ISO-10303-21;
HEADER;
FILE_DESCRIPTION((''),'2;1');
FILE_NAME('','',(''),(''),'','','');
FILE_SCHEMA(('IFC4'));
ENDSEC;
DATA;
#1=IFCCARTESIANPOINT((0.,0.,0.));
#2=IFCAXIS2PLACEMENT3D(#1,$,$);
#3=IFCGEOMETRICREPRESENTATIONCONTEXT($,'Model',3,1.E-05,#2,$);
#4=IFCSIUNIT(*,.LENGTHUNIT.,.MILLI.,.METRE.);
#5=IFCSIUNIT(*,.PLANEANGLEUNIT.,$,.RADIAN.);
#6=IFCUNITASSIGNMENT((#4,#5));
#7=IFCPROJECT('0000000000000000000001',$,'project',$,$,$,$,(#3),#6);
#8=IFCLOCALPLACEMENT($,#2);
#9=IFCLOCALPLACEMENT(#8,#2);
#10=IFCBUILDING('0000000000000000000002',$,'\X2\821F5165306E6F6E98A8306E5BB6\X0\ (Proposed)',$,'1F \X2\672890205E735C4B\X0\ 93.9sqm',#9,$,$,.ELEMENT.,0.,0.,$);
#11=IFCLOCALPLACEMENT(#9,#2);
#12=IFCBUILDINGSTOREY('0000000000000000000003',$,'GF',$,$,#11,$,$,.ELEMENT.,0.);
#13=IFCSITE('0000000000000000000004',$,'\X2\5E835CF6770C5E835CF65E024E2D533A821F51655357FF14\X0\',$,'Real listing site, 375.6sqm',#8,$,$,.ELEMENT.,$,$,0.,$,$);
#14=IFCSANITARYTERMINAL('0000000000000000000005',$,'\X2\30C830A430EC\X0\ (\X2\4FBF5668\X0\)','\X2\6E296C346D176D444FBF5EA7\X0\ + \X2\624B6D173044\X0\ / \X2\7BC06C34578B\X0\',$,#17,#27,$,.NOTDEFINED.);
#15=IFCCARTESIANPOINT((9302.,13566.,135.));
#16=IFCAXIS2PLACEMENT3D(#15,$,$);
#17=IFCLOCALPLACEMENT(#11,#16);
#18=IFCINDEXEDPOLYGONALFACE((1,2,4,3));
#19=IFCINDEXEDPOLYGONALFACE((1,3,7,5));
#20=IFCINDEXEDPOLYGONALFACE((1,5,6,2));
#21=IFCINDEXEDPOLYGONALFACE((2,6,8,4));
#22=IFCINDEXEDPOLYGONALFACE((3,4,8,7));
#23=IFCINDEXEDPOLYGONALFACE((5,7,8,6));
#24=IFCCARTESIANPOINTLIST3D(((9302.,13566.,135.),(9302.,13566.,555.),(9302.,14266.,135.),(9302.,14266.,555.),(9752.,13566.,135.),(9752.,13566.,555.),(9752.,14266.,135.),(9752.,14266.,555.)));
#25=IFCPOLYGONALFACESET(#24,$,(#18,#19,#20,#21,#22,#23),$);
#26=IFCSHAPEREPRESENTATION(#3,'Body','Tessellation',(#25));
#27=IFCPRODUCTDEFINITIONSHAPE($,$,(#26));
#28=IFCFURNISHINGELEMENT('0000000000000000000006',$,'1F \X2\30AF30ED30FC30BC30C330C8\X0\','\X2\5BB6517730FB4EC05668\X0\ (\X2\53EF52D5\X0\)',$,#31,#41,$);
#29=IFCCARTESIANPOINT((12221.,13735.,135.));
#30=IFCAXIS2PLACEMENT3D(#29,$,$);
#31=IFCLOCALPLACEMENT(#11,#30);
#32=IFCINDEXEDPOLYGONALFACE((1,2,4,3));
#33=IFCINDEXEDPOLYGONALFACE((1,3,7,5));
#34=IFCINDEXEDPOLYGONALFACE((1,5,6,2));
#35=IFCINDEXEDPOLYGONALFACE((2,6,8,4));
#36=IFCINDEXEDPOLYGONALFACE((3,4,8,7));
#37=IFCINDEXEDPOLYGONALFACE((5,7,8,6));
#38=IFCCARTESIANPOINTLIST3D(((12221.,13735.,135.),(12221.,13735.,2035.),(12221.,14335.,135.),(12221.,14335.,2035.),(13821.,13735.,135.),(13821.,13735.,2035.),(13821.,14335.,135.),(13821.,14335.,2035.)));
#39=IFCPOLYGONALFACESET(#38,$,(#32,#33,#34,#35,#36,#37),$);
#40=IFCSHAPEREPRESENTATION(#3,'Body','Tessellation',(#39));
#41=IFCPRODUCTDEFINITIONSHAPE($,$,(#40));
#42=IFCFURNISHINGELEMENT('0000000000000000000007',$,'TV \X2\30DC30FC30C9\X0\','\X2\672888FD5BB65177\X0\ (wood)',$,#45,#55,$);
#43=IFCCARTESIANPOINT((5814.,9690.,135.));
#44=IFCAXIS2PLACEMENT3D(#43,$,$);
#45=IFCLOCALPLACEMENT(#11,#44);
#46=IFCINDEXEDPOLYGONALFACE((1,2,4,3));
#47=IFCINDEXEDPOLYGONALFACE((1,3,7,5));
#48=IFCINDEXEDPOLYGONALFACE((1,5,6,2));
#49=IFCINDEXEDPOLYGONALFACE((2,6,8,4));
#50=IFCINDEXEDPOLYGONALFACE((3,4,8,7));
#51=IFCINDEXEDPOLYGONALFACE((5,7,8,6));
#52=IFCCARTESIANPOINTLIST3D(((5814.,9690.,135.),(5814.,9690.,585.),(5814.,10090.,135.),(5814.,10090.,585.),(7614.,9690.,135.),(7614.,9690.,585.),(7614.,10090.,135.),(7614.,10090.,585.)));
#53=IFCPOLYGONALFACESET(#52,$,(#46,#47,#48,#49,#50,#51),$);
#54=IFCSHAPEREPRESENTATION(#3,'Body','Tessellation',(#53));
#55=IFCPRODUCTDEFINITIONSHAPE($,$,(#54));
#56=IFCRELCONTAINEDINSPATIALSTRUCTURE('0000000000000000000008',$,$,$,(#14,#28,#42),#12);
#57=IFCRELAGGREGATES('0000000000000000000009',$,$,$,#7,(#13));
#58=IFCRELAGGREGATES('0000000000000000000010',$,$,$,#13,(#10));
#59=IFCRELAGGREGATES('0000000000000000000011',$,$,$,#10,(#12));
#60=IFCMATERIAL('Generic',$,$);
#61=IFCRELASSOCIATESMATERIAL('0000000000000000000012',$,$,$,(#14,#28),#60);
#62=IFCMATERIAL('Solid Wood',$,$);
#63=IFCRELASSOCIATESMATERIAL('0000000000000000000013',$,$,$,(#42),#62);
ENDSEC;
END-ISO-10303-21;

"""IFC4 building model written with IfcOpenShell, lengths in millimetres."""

from ifc_helpers import new_model, si_unit, frame, frame_2d, origin, place, context, project, spatial, rectangle, extrude, material, element, save


model = new_model("IFC4")

# Units and contexts
model_context = context("Model", 3, precision=1e-05, world=origin())
ifc_project = project(units=[si_unit("LENGTHUNIT", "METRE", prefix="MILLI"), si_unit("PLANEANGLEUNIT", "RADIAN")], contexts=[model_context])

# Site, building, storey
site_placement = place(None, origin())
site = spatial("IfcSite", under=ifc_project, at=site_placement, Name="広島県広島市中区舟入南４", ObjectType="Real listing site, 375.6sqm", CompositionType="ELEMENT", RefElevation=0.0)
building_placement = place(site_placement, origin())
building = spatial("IfcBuilding", under=site, at=building_placement, Name="舟入の潮風の家 (Proposed)", ObjectType="1F 木造平屋 93.9sqm", CompositionType="ELEMENT", ElevationOfRefHeight=0.0, ElevationOfTerrain=0.0)
storey_placement = place(building_placement, origin())
storey = spatial("IfcBuildingStorey", under=building, at=storey_placement, Name="GF", CompositionType="ELEMENT", Elevation=0.0)

# Shared definitions
ifc_material_1 = material(Name="Solid Wood")

# Sanitary terminal
ifc_material_2 = material(Name="Generic")
sanitary_terminal_1_placement = place(storey_placement, frame((9302.0, 13566.0, 135.0)))
element("IfcSanitaryTerminal", 1, at=sanitary_terminal_1_placement, inside=storey, material=ifc_material_2, Name="トイレ (便器)", Description="温水洗浄便座 + 手洗い / 節水型", PredefinedType="NOTDEFINED", context=model_context, shape_type="SweptSolid", body=[
    extrude(rectangle(XDim=450.0, YDim=700.0, at=frame_2d((225.0, 350.0))), frame((9302.0, 13566.0, 135.0)), (0.0, 0.0, 1.0), 420.0),
])

# Furnishing elements
furnishing_1_placement = place(storey_placement, frame((12221.0, 13735.0, 135.0)))
element("IfcFurnishingElement", 2, at=furnishing_1_placement, inside=storey, material=ifc_material_2, Name="1F クローゼット", Description="家具・什器 (可動)", context=model_context, shape_type="SweptSolid", body=[
    extrude(rectangle(XDim=1600.0, YDim=600.0, at=frame_2d((800.0, 300.0))), frame((12221.0, 13735.0, 135.0)), (0.0, 0.0, 1.0), 1900.0),
])
furnishing_2_placement = place(storey_placement, frame((5814.0, 9690.0, 135.0)))
element("IfcFurnishingElement", 3, at=furnishing_2_placement, inside=storey, material=ifc_material_1, Name="TV ボード", Description="木製家具 (wood)", context=model_context, shape_type="SweptSolid", body=[
    extrude(rectangle(XDim=1800.0, YDim=400.0, at=frame_2d((900.0, 200.0))), frame((5814.0, 9690.0, 135.0)), (0.0, 0.0, 1.0), 450.0),
])

save(model, "model.ifc")
